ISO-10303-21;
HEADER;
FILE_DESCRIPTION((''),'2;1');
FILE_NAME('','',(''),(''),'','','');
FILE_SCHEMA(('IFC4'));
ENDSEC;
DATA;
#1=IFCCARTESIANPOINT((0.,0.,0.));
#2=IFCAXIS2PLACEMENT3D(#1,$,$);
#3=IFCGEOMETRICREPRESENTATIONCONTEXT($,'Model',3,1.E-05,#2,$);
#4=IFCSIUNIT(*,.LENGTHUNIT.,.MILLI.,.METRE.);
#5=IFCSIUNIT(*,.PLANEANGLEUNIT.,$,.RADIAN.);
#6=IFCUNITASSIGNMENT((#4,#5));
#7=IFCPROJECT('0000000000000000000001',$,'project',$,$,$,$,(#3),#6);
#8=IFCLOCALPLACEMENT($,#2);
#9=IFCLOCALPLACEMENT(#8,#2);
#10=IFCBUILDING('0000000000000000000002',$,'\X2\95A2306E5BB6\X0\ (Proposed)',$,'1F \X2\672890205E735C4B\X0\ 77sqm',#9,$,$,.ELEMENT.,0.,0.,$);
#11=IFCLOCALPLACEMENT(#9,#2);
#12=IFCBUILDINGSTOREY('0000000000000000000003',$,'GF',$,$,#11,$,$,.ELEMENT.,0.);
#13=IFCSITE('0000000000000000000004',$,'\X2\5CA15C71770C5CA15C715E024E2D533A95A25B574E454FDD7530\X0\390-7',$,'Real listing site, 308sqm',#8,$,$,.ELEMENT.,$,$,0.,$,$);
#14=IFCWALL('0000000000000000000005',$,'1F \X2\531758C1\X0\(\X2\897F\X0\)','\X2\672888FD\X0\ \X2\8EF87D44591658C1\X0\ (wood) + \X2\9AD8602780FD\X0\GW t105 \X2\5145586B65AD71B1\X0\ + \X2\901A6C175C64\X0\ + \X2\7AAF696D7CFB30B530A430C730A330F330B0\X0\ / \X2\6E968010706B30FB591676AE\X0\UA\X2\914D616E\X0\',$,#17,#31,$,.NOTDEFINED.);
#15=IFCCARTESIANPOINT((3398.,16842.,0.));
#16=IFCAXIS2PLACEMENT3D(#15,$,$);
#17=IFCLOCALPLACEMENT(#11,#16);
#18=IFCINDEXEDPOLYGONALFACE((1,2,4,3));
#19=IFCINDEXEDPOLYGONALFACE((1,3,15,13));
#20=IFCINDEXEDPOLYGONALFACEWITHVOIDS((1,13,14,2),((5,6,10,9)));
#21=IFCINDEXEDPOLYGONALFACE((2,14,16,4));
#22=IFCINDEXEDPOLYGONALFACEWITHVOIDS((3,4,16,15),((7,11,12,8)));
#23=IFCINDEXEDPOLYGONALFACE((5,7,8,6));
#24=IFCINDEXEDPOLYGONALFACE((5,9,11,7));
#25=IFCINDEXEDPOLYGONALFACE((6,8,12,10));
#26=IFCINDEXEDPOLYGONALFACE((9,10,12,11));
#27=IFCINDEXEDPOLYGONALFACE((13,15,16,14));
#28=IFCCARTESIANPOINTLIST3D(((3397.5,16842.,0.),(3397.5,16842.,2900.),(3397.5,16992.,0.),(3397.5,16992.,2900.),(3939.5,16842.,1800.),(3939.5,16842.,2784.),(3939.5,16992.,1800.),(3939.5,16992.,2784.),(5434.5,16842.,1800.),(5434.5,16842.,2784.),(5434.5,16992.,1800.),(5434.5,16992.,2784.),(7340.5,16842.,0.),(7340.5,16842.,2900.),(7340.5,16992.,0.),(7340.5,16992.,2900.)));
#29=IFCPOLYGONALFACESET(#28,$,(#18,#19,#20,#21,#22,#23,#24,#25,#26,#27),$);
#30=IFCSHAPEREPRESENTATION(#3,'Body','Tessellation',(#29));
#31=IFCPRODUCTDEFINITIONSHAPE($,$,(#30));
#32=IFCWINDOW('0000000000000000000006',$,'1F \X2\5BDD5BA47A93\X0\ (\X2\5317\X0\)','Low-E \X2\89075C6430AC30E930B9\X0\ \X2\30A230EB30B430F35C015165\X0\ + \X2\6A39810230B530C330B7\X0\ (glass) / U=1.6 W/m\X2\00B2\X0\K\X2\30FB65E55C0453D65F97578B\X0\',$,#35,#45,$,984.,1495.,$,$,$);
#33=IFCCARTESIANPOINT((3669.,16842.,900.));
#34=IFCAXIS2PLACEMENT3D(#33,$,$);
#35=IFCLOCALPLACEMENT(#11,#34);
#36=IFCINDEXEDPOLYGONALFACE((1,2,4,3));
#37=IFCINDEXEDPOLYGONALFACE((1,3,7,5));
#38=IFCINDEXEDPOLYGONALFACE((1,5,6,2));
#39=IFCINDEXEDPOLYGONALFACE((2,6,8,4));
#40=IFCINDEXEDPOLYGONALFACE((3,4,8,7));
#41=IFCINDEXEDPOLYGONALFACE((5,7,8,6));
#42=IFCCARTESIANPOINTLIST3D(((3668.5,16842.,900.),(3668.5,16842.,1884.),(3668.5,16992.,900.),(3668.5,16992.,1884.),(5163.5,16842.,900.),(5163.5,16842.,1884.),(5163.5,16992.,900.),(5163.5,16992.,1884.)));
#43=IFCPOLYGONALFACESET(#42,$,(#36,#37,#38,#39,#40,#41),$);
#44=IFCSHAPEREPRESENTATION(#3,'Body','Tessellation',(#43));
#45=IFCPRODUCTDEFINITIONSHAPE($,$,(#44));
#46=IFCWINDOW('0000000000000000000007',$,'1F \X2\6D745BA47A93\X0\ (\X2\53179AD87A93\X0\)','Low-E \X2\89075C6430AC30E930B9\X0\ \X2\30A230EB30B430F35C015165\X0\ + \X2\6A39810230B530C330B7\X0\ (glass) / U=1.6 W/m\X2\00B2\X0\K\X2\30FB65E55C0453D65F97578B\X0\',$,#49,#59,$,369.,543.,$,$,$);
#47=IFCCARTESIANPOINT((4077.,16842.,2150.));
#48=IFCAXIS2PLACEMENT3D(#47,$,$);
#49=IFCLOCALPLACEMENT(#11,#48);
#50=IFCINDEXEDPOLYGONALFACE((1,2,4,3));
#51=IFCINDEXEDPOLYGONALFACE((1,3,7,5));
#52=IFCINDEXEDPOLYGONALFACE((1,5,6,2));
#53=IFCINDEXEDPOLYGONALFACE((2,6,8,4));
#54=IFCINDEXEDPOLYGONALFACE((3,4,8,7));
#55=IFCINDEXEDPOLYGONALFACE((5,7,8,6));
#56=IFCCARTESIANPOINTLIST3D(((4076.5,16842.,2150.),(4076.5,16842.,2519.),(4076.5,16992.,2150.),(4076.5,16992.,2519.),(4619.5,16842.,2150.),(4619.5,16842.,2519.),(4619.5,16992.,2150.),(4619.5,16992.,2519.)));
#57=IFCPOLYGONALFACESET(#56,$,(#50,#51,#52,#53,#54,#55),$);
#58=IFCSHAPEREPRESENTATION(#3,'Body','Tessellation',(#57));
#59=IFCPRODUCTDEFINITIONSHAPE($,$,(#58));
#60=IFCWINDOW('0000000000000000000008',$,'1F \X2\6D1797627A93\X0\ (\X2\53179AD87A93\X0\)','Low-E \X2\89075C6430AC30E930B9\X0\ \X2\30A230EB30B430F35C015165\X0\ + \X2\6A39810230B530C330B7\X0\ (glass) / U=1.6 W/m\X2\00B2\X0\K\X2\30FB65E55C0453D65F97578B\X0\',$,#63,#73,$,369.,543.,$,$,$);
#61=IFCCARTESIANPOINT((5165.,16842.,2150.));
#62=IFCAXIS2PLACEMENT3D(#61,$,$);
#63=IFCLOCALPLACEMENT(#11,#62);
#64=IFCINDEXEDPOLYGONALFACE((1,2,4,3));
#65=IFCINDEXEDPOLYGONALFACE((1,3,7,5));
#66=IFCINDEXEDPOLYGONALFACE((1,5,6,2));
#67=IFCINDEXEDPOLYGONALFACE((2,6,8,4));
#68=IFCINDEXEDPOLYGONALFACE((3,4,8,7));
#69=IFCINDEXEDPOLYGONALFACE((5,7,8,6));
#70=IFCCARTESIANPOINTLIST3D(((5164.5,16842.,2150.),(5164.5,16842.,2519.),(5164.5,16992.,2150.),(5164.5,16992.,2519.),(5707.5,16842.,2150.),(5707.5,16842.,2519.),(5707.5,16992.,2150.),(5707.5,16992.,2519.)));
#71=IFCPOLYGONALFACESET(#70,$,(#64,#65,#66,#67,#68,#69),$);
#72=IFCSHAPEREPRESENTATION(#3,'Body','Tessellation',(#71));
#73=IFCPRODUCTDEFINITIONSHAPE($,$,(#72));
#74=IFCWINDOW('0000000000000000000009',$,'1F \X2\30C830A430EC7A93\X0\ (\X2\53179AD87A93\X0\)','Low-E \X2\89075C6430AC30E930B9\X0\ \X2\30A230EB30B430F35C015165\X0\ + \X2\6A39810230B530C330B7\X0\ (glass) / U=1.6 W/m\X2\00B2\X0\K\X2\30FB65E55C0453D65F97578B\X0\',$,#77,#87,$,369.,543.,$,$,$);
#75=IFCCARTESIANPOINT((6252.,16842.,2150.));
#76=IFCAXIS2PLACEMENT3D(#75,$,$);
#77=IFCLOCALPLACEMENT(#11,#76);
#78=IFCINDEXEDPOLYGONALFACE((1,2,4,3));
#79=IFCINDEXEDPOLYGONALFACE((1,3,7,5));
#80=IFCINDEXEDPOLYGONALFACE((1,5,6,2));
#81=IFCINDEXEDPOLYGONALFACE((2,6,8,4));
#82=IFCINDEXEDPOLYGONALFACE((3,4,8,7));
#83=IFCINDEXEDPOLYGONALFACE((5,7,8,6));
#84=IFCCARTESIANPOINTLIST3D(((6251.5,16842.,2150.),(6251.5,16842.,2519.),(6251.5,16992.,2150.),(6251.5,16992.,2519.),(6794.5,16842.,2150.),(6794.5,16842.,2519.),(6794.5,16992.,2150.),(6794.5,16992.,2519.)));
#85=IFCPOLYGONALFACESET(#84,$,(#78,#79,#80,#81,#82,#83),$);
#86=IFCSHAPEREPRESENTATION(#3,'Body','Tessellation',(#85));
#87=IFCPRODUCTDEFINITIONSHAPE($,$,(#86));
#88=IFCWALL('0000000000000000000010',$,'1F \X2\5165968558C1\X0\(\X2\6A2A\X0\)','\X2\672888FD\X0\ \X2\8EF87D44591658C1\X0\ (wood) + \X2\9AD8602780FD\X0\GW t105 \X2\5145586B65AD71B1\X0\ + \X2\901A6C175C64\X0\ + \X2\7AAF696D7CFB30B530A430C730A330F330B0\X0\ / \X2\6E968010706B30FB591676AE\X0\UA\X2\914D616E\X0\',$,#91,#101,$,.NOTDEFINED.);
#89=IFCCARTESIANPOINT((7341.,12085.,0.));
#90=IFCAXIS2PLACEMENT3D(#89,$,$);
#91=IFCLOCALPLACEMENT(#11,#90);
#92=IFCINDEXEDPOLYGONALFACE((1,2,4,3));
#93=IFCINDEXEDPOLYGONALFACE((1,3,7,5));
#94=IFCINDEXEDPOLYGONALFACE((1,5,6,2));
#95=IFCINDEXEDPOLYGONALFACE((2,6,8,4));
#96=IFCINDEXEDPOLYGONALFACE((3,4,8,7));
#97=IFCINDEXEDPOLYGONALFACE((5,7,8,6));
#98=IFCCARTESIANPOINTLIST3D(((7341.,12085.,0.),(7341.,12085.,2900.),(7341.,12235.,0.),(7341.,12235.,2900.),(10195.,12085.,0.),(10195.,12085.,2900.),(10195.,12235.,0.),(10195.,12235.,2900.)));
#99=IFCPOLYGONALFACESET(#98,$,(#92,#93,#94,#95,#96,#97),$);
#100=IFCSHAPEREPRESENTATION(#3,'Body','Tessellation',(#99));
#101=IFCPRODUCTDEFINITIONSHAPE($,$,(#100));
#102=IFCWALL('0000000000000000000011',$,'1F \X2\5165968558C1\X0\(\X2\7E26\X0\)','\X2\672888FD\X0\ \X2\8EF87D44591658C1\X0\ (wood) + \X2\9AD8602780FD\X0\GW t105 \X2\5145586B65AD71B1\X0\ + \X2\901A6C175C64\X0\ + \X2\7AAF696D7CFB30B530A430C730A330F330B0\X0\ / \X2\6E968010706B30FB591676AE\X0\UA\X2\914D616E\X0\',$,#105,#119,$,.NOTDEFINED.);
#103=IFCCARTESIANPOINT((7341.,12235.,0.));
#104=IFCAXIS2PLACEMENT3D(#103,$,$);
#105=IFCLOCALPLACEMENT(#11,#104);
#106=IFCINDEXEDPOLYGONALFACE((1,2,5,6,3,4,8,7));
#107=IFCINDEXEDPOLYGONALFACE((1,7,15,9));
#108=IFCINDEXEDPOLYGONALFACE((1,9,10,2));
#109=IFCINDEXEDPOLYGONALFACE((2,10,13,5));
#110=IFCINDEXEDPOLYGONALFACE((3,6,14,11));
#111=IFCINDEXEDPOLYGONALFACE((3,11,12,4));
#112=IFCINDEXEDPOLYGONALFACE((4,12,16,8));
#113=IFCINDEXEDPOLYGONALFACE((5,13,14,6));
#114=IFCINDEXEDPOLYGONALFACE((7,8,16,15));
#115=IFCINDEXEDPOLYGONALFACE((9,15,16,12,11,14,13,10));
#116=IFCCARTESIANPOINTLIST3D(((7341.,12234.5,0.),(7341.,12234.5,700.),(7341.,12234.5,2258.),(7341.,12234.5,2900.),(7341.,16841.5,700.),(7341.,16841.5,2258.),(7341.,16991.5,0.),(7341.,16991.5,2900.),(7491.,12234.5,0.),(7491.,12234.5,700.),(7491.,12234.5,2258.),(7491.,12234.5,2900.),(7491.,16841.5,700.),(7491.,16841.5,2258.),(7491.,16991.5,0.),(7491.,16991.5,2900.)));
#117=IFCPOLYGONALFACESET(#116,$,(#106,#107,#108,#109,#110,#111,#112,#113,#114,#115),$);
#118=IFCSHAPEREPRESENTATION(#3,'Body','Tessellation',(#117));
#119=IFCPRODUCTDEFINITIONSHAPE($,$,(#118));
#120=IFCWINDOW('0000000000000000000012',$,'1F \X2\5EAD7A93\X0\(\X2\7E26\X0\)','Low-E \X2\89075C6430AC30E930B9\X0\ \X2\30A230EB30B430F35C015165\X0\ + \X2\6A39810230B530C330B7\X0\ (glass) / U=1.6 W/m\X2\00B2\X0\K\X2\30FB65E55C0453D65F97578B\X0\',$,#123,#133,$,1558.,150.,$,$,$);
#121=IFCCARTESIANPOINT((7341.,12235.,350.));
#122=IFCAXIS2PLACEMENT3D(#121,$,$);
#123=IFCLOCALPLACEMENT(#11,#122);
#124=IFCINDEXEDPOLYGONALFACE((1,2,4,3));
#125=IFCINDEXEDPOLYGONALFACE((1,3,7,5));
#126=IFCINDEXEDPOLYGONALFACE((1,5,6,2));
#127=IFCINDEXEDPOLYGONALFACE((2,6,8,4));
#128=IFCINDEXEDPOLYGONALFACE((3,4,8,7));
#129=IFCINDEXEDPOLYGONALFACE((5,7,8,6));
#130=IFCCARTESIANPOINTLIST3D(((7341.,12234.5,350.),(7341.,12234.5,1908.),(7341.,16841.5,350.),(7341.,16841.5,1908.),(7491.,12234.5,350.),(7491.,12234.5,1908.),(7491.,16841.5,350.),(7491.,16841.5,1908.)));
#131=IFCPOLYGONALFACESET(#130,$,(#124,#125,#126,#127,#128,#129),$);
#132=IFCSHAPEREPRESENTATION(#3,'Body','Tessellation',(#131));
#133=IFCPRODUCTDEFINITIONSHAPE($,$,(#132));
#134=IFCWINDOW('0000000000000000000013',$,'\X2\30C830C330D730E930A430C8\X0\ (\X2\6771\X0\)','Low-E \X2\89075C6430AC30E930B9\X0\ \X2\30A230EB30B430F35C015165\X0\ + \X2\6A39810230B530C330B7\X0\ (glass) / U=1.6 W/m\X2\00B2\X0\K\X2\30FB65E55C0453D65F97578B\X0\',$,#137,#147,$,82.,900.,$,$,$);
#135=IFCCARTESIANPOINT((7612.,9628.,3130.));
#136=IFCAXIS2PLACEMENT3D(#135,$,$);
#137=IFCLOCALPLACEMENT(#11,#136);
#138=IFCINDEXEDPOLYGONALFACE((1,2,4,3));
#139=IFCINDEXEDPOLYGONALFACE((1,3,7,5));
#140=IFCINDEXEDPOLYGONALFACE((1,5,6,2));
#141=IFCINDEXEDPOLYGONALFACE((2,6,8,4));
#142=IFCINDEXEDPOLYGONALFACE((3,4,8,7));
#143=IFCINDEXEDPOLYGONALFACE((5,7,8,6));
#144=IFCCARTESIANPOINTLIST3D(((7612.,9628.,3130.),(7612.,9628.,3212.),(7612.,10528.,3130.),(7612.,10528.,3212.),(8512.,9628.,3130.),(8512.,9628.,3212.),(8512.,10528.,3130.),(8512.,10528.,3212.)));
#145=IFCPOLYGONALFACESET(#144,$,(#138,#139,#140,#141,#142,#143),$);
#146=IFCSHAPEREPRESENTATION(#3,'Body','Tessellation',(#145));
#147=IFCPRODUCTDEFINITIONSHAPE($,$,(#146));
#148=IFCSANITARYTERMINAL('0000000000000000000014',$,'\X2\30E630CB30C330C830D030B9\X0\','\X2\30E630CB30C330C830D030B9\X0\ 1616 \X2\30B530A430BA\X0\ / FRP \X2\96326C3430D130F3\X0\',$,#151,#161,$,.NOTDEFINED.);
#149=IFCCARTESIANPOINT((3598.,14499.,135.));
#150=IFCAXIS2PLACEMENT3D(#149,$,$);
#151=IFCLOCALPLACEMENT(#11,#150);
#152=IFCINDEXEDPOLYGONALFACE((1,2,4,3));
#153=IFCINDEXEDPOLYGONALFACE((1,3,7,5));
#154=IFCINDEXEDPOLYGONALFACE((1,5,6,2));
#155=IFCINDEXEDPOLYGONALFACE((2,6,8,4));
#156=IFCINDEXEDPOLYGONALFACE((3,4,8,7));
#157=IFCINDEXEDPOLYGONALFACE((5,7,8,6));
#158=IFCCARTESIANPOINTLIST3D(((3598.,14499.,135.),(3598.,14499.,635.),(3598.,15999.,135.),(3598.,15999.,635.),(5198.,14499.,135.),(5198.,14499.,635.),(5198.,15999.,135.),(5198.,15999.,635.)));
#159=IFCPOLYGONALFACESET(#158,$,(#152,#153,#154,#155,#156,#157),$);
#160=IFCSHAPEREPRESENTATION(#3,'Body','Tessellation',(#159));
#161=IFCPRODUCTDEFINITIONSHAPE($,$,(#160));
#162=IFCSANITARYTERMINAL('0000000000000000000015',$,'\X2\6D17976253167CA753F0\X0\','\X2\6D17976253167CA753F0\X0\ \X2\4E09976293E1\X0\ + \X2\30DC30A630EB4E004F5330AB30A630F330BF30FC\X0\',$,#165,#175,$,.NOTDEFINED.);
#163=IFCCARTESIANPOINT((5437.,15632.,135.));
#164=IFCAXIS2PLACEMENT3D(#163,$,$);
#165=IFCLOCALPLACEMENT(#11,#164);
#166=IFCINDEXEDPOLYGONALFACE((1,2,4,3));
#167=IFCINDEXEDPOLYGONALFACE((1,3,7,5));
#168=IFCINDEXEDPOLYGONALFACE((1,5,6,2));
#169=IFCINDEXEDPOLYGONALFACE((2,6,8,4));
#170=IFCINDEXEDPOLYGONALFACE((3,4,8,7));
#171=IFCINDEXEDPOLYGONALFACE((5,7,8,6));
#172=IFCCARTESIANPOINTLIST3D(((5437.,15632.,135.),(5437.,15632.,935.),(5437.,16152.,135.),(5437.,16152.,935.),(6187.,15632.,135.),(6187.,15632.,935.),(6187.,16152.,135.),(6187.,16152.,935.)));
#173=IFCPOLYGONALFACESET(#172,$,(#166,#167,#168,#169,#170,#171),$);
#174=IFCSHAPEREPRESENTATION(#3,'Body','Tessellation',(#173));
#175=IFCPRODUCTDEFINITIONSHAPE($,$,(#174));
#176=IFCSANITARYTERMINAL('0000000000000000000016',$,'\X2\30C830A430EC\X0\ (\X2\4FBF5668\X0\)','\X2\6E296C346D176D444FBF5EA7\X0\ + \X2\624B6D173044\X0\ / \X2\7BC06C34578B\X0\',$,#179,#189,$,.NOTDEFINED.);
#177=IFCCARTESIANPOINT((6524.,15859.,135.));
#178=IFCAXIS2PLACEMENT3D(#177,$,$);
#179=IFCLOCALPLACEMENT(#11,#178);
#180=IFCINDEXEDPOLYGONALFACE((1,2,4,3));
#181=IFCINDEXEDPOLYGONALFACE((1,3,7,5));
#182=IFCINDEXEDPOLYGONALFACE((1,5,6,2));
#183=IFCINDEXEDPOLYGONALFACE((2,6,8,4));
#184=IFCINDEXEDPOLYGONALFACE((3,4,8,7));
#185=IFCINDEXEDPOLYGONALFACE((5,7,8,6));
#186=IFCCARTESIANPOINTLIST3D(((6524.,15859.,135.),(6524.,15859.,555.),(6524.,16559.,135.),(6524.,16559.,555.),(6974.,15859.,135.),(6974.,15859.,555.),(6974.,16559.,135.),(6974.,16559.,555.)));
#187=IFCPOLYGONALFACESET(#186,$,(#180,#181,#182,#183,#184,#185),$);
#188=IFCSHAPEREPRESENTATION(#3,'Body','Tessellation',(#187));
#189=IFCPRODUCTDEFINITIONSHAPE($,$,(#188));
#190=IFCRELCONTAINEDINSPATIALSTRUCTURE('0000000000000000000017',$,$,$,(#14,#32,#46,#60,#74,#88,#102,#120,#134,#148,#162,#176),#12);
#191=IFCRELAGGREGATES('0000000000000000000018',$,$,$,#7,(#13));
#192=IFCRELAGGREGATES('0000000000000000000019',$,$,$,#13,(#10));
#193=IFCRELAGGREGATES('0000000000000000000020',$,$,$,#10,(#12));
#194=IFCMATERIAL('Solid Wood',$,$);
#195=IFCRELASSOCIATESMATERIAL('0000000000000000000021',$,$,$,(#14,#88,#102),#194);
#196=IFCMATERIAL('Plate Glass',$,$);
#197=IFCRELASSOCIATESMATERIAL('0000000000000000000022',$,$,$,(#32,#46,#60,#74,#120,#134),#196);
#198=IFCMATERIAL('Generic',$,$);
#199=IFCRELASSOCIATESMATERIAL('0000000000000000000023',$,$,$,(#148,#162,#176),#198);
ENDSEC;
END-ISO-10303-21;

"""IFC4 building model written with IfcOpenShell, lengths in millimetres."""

from ifc_helpers import new_model, si_unit, frame, frame_2d, origin, place, context, project, spatial, rectangle, extrude, material, element, fill, save


model = new_model("IFC4")

# Units and contexts
model_context = context("Model", 3, precision=1e-05, world=origin())
ifc_project = project(units=[si_unit("LENGTHUNIT", "METRE", prefix="MILLI"), si_unit("PLANEANGLEUNIT", "RADIAN")], contexts=[model_context])

# Site, building, storey
site_placement = place(None, origin())
site = spatial("IfcSite", under=ifc_project, at=site_placement, Name="岡山県岡山市中区関字久保田390-7", ObjectType="Real listing site, 308sqm", CompositionType="ELEMENT", RefElevation=0.0)
building_placement = place(site_placement, origin())
building = spatial("IfcBuilding", under=site, at=building_placement, Name="関の家 (Proposed)", ObjectType="1F 木造平屋 77sqm", CompositionType="ELEMENT", ElevationOfRefHeight=0.0, ElevationOfTerrain=0.0)
storey_placement = place(building_placement, origin())
storey = spatial("IfcBuildingStorey", under=building, at=storey_placement, Name="GF", CompositionType="ELEMENT", Elevation=0.0)

# Shared definitions
ifc_material_1 = material(Name="Solid Wood")

# Wall, openings, windows
wall_1_placement = place(storey_placement, frame((3398.0, 16842.0, 0.0)))
wall_1 = element("IfcWall", 1, at=wall_1_placement, inside=storey, material=ifc_material_1, Name="1F 北壁(西)", Description="木製 軸組外壁 (wood) + 高性能GW t105 充填断熱 + 通気層 + 窯業系サイディング / 準耐火・外皮UA配慮", PredefinedType="NOTDEFINED", context=model_context, shape_type="SweptSolid", body=[
    extrude(rectangle(XDim=3943.0, YDim=150.0, at=frame_2d((1971.0, 75.0))), frame((3398.0, 16842.0, 0.0)), (0.0, 0.0, 1.0), 2900.0),
])
opening_1_placement = place(storey_placement, frame((3669.0, 16842.0, 900.0)))
opening_1 = element("IfcOpeningElement", 2, at=opening_1_placement, cuts=wall_1, PredefinedType="NOTDEFINED", context=model_context, shape_type="SweptSolid", body=[
    extrude(rectangle(XDim=1495.0, YDim=150.0, at=frame_2d((747.0, 75.0))), frame((3669.0, 16842.0, 900.0)), (0.0, 0.0, 1.0), 984.0),
])
opening_2_placement = place(storey_placement, frame((4077.0, 16842.0, 2150.0)))
opening_2 = element("IfcOpeningElement", 3, at=opening_2_placement, cuts=wall_1, PredefinedType="NOTDEFINED", context=model_context, shape_type="SweptSolid", body=[
    extrude(rectangle(XDim=543.0, YDim=150.0, at=frame_2d((271.0, 75.0))), frame((4077.0, 16842.0, 2150.0)), (0.0, 0.0, 1.0), 369.0),
])
opening_3_placement = place(storey_placement, frame((5165.0, 16842.0, 2150.0)))
opening_3 = element("IfcOpeningElement", 4, at=opening_3_placement, cuts=wall_1, PredefinedType="NOTDEFINED", context=model_context, shape_type="SweptSolid", body=[
    extrude(rectangle(XDim=543.0, YDim=150.0, at=frame_2d((271.0, 75.0))), frame((5165.0, 16842.0, 2150.0)), (0.0, 0.0, 1.0), 369.0),
])
opening_4_placement = place(storey_placement, frame((6252.0, 16842.0, 2150.0)))
opening_4 = element("IfcOpeningElement", 5, at=opening_4_placement, cuts=wall_1, PredefinedType="NOTDEFINED", context=model_context, shape_type="SweptSolid", body=[
    extrude(rectangle(XDim=543.0, YDim=150.0, at=frame_2d((271.0, 75.0))), frame((6252.0, 16842.0, 2150.0)), (0.0, 0.0, 1.0), 369.0),
])
ifc_material_2 = material(Name="Plate Glass")
window_1_placement = place(storey_placement, frame((3669.0, 16842.0, 900.0)))
window_1 = element("IfcWindow", 6, at=window_1_placement, inside=storey, material=ifc_material_2, Name="1F 寝室窓 (北)", Description="Low-E 複層ガラス アルゴン封入 + 樹脂サッシ (glass) / U=1.6 W/m²K・日射取得型", OverallHeight=984.0, OverallWidth=1495.0, context=model_context, shape_type="SweptSolid", body=[
    extrude(rectangle(XDim=1495.0, YDim=150.0, at=frame_2d((747.0, 75.0))), frame((3669.0, 16842.0, 900.0)), (0.0, 0.0, 1.0), 984.0),
])
fill(opening_1, window_1)
window_2_placement = place(storey_placement, frame((4077.0, 16842.0, 2150.0)))
window_2 = element("IfcWindow", 7, at=window_2_placement, inside=storey, material=ifc_material_2, Name="1F 浴室窓 (北高窓)", Description="Low-E 複層ガラス アルゴン封入 + 樹脂サッシ (glass) / U=1.6 W/m²K・日射取得型", OverallHeight=369.0, OverallWidth=543.0, context=model_context, shape_type="SweptSolid", body=[
    extrude(rectangle(XDim=543.0, YDim=150.0, at=frame_2d((271.0, 75.0))), frame((4077.0, 16842.0, 2150.0)), (0.0, 0.0, 1.0), 369.0),
])
fill(opening_2, window_2)
window_3_placement = place(storey_placement, frame((5165.0, 16842.0, 2150.0)))
window_3 = element("IfcWindow", 8, at=window_3_placement, inside=storey, material=ifc_material_2, Name="1F 洗面窓 (北高窓)", Description="Low-E 複層ガラス アルゴン封入 + 樹脂サッシ (glass) / U=1.6 W/m²K・日射取得型", OverallHeight=369.0, OverallWidth=543.0, context=model_context, shape_type="SweptSolid", body=[
    extrude(rectangle(XDim=543.0, YDim=150.0, at=frame_2d((271.0, 75.0))), frame((5165.0, 16842.0, 2150.0)), (0.0, 0.0, 1.0), 369.0),
])
fill(opening_3, window_3)
window_4_placement = place(storey_placement, frame((6252.0, 16842.0, 2150.0)))
window_4 = element("IfcWindow", 9, at=window_4_placement, inside=storey, material=ifc_material_2, Name="1F トイレ窓 (北高窓)", Description="Low-E 複層ガラス アルゴン封入 + 樹脂サッシ (glass) / U=1.6 W/m²K・日射取得型", OverallHeight=369.0, OverallWidth=543.0, context=model_context, shape_type="SweptSolid", body=[
    extrude(rectangle(XDim=543.0, YDim=150.0, at=frame_2d((271.0, 75.0))), frame((6252.0, 16842.0, 2150.0)), (0.0, 0.0, 1.0), 369.0),
])
fill(opening_4, window_4)

# Wall
wall_2_placement = place(storey_placement, frame((7341.0, 12085.0, 0.0)))
element("IfcWall", 10, at=wall_2_placement, inside=storey, material=ifc_material_1, Name="1F 入隅壁(横)", Description="木製 軸組外壁 (wood) + 高性能GW t105 充填断熱 + 通気層 + 窯業系サイディング / 準耐火・外皮UA配慮", PredefinedType="NOTDEFINED", context=model_context, shape_type="SweptSolid", body=[
    extrude(rectangle(XDim=2854.0, YDim=150.0, at=frame_2d((1427.0, 75.0))), frame((7341.0, 12085.0, 0.0)), (0.0, 0.0, 1.0), 2900.0),
])

# Wall, opening, window
wall_3_placement = place(storey_placement, frame((7341.0, 12235.0, 0.0)))
wall_3 = element("IfcWall", 11, at=wall_3_placement, inside=storey, material=ifc_material_1, Name="1F 入隅壁(縦)", Description="木製 軸組外壁 (wood) + 高性能GW t105 充填断熱 + 通気層 + 窯業系サイディング / 準耐火・外皮UA配慮", PredefinedType="NOTDEFINED", context=model_context, shape_type="SweptSolid", body=[
    extrude(rectangle(XDim=150.0, YDim=4757.0, at=frame_2d((75.0, 2378.0))), frame((7341.0, 12235.0, 0.0)), (0.0, 0.0, 1.0), 2900.0),
])
opening_5_placement = place(storey_placement, frame((7341.0, 12235.0, 350.0)))
opening_5 = element("IfcOpeningElement", 12, at=opening_5_placement, cuts=wall_3, PredefinedType="NOTDEFINED", context=model_context, shape_type="SweptSolid", body=[
    extrude(rectangle(XDim=150.0, YDim=4607.0, at=frame_2d((75.0, 2303.0))), frame((7341.0, 12235.0, 350.0)), (0.0, 0.0, 1.0), 1558.0),
])
window_5_placement = place(storey_placement, frame((7341.0, 12235.0, 350.0)))
window_5 = element("IfcWindow", 13, at=window_5_placement, inside=storey, material=ifc_material_2, Name="1F 庭窓(縦)", Description="Low-E 複層ガラス アルゴン封入 + 樹脂サッシ (glass) / U=1.6 W/m²K・日射取得型", OverallHeight=1558.0, OverallWidth=150.0, context=model_context, shape_type="SweptSolid", body=[
    extrude(rectangle(XDim=150.0, YDim=4607.0, at=frame_2d((75.0, 2303.0))), frame((7341.0, 12235.0, 350.0)), (0.0, 0.0, 1.0), 1558.0),
])
fill(opening_5, window_5)

# Window
window_6_placement = place(storey_placement, frame((7612.0, 9628.0, 3130.0)))
element("IfcWindow", 14, at=window_6_placement, inside=storey, material=ifc_material_2, Name="トップライト (東)", Description="Low-E 複層ガラス アルゴン封入 + 樹脂サッシ (glass) / U=1.6 W/m²K・日射取得型", OverallHeight=82.0, OverallWidth=900.0, context=model_context, shape_type="SweptSolid", body=[
    extrude(rectangle(XDim=900.0, YDim=900.0, at=frame_2d((450.0, 450.0))), frame((7612.0, 9628.0, 3130.0)), (0.0, 0.0, 1.0), 82.0),
])

# Shared definitions
ifc_material_3 = material(Name="Generic")

# Sanitary terminals
sanitary_terminal_1_placement = place(storey_placement, frame((3598.0, 14499.0, 135.0)))
element("IfcSanitaryTerminal", 15, at=sanitary_terminal_1_placement, inside=storey, material=ifc_material_3, Name="ユニットバス", Description="ユニットバス 1616 サイズ / FRP 防水パン", PredefinedType="NOTDEFINED", context=model_context, shape_type="SweptSolid", body=[
    extrude(rectangle(XDim=1600.0, YDim=1500.0, at=frame_2d((800.0, 750.0))), frame((3598.0, 14499.0, 135.0)), (0.0, 0.0, 1.0), 500.0),
])
sanitary_terminal_2_placement = place(storey_placement, frame((5437.0, 15632.0, 135.0)))
element("IfcSanitaryTerminal", 16, at=sanitary_terminal_2_placement, inside=storey, material=ifc_material_3, Name="洗面化粧台", Description="洗面化粧台 三面鏡 + ボウル一体カウンター", PredefinedType="NOTDEFINED", context=model_context, shape_type="SweptSolid", body=[
    extrude(rectangle(XDim=750.0, YDim=520.0, at=frame_2d((375.0, 260.0))), frame((5437.0, 15632.0, 135.0)), (0.0, 0.0, 1.0), 800.0),
])
sanitary_terminal_3_placement = place(storey_placement, frame((6524.0, 15859.0, 135.0)))
element("IfcSanitaryTerminal", 17, at=sanitary_terminal_3_placement, inside=storey, material=ifc_material_3, Name="トイレ (便器)", Description="温水洗浄便座 + 手洗い / 節水型", PredefinedType="NOTDEFINED", context=model_context, shape_type="SweptSolid", body=[
    extrude(rectangle(XDim=450.0, YDim=700.0, at=frame_2d((225.0, 350.0))), frame((6524.0, 15859.0, 135.0)), (0.0, 0.0, 1.0), 420.0),
])

save(model, "model.ifc")
